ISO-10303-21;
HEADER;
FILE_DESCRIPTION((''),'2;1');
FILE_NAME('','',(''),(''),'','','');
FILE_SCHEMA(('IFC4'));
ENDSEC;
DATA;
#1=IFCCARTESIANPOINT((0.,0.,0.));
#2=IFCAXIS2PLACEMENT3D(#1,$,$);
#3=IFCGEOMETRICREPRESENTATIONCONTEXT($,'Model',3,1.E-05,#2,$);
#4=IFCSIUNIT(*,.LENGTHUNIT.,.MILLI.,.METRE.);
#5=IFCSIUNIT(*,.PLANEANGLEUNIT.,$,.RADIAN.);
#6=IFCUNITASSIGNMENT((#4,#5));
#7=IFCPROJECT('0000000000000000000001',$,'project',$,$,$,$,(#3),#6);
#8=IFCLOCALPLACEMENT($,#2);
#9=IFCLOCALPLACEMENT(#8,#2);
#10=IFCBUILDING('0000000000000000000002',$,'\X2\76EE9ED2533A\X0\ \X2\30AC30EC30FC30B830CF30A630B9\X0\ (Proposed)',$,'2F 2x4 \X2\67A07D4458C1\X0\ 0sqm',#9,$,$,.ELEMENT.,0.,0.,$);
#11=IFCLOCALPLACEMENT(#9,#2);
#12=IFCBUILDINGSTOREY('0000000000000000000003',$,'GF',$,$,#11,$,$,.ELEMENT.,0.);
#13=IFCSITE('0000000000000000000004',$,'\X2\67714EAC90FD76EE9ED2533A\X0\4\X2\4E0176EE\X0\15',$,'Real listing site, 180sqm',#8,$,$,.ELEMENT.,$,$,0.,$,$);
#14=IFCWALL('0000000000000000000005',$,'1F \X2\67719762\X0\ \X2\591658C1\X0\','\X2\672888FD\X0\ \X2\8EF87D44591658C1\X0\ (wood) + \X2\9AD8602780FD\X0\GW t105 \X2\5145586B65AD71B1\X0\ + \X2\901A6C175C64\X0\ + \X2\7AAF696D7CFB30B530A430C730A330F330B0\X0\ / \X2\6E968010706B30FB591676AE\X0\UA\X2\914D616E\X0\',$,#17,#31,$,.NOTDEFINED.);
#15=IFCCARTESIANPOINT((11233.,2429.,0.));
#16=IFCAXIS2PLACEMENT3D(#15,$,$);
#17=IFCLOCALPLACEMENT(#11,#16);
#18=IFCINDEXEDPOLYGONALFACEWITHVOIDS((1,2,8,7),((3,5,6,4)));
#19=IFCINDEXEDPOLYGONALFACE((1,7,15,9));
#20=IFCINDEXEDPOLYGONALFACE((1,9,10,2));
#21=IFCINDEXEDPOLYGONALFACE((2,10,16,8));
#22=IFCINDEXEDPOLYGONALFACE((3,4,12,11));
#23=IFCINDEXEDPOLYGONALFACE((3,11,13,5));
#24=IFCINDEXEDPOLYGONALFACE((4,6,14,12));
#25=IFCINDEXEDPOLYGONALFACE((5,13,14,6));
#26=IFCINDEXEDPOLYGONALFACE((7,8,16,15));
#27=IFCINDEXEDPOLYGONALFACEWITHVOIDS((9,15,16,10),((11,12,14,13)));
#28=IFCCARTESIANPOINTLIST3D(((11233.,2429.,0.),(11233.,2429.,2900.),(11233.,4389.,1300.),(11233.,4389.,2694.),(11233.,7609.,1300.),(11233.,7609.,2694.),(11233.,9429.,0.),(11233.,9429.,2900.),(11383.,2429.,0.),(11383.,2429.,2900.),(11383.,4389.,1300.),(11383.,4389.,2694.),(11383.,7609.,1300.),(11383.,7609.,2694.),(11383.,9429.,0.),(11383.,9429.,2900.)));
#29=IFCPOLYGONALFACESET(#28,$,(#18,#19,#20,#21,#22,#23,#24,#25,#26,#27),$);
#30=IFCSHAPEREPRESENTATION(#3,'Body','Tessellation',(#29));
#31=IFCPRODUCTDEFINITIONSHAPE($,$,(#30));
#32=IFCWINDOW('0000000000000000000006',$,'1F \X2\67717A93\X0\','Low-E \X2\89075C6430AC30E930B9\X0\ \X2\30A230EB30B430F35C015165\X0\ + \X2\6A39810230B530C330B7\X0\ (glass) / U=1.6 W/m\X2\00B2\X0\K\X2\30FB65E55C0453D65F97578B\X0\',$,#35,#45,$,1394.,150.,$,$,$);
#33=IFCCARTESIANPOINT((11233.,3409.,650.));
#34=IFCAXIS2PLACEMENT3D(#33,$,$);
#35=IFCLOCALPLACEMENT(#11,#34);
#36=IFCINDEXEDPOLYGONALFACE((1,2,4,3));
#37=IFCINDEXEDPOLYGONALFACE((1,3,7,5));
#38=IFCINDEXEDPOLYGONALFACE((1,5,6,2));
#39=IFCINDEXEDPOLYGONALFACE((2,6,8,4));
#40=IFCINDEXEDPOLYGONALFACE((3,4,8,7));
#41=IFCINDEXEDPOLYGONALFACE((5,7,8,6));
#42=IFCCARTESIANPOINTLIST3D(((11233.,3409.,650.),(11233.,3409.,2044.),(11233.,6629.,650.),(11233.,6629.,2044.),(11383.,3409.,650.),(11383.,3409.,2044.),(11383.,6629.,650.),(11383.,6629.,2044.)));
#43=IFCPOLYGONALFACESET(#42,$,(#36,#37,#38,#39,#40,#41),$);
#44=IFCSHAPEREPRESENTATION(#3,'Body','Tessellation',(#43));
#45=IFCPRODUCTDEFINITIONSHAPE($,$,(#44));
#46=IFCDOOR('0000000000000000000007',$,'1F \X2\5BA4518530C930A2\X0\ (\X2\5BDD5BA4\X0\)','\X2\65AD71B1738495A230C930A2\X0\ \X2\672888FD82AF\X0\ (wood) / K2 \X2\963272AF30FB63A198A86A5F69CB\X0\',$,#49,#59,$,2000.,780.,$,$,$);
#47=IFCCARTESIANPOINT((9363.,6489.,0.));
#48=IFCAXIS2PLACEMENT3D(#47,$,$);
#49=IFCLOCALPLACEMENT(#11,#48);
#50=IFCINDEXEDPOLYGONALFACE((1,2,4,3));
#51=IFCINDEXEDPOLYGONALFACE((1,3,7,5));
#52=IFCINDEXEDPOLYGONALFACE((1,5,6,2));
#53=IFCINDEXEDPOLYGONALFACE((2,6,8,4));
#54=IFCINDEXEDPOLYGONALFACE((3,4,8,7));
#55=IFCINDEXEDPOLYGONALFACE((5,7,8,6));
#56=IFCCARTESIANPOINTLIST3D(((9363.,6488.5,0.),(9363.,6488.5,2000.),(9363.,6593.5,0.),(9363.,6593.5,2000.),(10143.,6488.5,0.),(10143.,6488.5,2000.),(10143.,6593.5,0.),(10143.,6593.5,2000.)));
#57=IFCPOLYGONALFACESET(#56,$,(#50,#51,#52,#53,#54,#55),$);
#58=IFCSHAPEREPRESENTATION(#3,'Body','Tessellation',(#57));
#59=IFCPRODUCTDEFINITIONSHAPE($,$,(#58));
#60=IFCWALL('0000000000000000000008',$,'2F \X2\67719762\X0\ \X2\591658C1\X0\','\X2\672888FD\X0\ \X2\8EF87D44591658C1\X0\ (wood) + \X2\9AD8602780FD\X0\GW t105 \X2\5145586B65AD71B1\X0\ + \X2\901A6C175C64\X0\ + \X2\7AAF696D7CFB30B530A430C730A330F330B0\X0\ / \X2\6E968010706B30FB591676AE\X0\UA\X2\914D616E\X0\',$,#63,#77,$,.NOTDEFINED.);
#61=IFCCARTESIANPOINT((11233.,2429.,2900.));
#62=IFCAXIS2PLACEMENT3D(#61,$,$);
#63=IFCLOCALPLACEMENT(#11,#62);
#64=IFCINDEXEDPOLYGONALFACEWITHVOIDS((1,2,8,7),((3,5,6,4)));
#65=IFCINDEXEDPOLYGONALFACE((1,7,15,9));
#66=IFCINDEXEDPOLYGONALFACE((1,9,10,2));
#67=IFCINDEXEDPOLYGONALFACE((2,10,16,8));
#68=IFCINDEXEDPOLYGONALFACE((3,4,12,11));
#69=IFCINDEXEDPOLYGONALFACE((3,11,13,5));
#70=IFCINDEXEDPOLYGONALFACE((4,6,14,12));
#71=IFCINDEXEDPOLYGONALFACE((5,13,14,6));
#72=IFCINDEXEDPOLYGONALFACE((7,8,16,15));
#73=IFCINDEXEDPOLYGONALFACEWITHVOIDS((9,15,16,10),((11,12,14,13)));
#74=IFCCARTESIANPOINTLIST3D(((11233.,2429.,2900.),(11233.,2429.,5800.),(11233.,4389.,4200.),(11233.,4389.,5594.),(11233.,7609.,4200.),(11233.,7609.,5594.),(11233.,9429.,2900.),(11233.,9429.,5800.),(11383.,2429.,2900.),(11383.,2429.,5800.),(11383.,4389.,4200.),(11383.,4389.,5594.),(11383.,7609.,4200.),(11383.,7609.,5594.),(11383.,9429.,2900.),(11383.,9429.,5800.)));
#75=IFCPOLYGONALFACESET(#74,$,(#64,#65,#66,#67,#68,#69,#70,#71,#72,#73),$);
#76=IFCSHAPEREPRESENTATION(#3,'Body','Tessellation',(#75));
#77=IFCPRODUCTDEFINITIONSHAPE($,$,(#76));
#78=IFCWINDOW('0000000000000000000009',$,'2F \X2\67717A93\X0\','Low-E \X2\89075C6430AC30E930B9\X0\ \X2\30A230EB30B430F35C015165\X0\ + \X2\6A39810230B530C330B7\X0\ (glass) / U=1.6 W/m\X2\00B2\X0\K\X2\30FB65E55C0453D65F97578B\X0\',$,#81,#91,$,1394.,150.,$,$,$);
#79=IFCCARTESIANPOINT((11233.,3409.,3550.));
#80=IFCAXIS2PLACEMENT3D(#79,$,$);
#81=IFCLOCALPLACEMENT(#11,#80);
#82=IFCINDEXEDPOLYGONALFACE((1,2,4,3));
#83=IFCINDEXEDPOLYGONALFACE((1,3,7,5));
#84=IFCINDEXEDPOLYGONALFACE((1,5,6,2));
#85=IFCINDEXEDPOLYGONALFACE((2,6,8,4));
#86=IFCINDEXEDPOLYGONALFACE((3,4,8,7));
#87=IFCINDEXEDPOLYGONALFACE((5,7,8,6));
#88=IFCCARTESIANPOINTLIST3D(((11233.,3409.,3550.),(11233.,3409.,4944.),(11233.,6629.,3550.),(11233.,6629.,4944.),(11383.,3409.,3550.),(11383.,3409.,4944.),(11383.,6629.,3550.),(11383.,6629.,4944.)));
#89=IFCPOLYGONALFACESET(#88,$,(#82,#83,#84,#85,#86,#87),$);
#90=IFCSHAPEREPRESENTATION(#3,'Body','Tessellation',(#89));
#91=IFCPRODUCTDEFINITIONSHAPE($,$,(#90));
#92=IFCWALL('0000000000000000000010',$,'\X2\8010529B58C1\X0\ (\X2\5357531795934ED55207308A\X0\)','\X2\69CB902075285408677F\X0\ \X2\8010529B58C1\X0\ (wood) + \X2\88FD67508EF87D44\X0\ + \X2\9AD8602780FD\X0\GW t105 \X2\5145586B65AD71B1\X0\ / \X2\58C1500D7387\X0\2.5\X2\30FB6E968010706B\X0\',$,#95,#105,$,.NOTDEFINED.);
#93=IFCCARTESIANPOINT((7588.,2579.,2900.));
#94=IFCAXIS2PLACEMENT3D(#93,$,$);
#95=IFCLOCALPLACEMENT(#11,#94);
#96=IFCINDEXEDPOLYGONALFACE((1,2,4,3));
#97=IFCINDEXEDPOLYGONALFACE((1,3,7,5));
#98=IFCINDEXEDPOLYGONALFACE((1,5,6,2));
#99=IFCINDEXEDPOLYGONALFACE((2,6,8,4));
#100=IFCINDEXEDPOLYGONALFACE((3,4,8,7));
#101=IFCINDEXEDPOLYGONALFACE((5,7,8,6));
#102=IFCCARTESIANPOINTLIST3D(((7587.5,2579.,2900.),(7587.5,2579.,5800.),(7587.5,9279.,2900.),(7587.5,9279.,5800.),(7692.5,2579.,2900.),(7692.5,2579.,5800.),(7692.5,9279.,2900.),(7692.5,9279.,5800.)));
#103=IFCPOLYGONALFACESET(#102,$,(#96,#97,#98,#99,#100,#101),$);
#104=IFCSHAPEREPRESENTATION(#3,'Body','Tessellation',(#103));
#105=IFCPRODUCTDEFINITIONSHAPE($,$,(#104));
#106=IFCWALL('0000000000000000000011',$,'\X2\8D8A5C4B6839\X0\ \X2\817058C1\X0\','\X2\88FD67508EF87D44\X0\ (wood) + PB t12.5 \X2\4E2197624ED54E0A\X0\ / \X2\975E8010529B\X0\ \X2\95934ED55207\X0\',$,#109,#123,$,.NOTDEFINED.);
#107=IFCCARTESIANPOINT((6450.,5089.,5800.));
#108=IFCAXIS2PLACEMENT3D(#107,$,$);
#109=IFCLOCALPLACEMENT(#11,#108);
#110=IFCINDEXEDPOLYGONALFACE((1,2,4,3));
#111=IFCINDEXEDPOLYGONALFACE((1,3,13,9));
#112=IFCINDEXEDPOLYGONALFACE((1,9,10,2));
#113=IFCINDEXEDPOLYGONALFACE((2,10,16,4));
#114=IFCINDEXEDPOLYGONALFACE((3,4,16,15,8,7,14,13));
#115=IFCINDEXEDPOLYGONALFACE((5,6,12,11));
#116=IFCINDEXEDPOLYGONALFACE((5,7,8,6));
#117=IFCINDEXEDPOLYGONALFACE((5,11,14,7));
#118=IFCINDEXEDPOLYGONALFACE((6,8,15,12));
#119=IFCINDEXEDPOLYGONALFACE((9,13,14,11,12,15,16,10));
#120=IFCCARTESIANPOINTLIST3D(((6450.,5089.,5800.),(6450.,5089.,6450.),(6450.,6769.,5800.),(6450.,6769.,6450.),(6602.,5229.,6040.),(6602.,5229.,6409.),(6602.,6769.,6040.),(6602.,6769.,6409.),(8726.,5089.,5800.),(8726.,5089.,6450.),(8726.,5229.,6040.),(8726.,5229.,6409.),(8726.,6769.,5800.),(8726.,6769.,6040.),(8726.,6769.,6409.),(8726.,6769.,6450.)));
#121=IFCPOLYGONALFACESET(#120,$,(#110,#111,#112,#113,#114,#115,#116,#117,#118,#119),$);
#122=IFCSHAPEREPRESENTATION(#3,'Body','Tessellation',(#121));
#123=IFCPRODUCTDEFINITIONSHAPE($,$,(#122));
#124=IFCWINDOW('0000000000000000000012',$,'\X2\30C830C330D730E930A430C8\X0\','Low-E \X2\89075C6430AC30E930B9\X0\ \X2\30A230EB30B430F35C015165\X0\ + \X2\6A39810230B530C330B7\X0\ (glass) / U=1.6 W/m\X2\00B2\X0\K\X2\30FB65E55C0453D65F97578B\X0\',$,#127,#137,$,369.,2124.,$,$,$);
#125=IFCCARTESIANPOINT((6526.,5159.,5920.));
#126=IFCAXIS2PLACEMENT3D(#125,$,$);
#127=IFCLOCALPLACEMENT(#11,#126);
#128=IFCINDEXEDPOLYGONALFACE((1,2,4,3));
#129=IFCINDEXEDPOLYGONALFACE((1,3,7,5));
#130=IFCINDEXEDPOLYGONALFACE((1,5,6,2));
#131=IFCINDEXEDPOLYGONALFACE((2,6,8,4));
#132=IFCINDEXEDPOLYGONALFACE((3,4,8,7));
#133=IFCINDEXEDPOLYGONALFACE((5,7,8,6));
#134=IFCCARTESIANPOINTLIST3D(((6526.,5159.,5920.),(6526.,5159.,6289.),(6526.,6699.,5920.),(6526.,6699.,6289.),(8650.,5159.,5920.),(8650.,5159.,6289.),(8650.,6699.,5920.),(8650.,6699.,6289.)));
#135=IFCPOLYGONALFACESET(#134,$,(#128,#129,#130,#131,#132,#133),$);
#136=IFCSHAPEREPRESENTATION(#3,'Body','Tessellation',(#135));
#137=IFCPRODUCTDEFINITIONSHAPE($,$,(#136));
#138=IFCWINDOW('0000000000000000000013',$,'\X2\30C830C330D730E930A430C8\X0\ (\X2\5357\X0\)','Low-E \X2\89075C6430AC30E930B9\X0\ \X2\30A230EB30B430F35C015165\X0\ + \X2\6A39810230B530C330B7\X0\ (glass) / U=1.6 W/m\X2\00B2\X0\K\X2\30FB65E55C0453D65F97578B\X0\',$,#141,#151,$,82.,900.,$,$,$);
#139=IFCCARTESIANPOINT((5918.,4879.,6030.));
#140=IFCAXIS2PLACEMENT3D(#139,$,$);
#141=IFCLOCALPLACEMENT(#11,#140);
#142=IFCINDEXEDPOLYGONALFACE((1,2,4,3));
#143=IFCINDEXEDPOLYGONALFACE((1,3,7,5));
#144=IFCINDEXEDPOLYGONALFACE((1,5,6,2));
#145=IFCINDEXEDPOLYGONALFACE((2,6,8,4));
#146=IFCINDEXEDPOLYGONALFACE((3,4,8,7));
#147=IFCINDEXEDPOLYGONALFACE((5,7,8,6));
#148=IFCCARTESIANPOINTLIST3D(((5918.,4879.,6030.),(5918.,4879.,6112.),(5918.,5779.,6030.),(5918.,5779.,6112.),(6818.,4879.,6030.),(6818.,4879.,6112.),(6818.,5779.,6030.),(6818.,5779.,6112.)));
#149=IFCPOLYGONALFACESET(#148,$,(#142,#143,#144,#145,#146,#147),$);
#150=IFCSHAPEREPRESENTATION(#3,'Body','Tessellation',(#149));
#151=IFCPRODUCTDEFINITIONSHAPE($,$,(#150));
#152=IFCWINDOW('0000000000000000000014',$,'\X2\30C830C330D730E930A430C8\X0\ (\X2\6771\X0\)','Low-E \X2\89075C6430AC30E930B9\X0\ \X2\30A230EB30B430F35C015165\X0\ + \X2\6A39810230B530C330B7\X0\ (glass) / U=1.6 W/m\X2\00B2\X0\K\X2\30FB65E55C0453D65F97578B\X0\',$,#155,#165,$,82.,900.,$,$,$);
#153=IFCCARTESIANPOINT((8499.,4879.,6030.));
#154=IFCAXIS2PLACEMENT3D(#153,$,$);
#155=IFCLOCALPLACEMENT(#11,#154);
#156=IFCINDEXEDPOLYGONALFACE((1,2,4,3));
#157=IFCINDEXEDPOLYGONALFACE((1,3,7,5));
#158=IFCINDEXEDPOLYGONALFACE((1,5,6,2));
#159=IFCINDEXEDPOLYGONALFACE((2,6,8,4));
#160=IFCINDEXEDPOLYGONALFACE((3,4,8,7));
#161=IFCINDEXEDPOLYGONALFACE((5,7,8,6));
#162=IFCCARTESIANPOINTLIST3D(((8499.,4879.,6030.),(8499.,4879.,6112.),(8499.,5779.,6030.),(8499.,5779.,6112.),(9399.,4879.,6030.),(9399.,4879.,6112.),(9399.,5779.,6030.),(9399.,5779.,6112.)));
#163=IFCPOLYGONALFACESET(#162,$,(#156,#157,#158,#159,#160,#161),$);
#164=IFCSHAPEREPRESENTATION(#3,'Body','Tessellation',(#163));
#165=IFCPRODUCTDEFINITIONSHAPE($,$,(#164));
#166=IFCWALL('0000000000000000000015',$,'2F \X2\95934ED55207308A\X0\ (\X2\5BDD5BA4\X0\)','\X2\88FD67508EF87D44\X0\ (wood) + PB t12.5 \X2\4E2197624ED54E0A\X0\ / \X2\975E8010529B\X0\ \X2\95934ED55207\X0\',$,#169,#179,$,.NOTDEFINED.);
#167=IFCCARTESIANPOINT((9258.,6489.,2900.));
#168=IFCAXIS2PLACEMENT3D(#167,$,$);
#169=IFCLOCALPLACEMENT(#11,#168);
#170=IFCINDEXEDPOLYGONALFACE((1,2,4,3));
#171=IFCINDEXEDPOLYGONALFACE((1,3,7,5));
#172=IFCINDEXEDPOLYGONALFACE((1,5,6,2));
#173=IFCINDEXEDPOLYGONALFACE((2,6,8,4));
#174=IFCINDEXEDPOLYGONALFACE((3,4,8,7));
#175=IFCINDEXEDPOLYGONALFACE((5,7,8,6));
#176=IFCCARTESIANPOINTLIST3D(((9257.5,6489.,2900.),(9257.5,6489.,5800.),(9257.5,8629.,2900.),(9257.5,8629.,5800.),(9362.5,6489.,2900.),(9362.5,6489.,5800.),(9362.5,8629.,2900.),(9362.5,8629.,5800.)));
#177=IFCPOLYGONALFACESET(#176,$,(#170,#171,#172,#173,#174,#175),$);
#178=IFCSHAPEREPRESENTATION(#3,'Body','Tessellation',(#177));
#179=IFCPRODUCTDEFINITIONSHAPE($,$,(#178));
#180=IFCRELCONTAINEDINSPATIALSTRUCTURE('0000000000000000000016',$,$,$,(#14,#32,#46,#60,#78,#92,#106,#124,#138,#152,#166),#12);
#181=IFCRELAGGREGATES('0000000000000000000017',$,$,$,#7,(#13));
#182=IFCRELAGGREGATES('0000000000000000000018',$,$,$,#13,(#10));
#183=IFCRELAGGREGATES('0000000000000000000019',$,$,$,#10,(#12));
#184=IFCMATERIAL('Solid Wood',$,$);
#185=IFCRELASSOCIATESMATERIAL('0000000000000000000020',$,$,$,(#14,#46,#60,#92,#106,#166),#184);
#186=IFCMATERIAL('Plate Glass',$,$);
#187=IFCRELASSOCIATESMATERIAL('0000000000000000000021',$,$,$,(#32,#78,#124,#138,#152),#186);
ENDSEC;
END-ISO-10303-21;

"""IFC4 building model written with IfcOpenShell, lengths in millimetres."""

from ifc_helpers import new_model, si_unit, frame, frame_2d, origin, place, context, project, spatial, rectangle, extrude, material, element, fill, save


model = new_model("IFC4")

# Units and contexts
model_context = context("Model", 3, precision=1e-05, world=origin())
ifc_project = project(units=[si_unit("LENGTHUNIT", "METRE", prefix="MILLI"), si_unit("PLANEANGLEUNIT", "RADIAN")], contexts=[model_context])

# Site, building, storey
site_placement = place(None, origin())
site = spatial("IfcSite", under=ifc_project, at=site_placement, Name="東京都目黒区4丁目15", ObjectType="Real listing site, 180sqm", CompositionType="ELEMENT", RefElevation=0.0)
building_placement = place(site_placement, origin())
building = spatial("IfcBuilding", under=site, at=building_placement, Name="目黒区 ガレージハウス (Proposed)", ObjectType="2F 2x4 枠組壁 0sqm", CompositionType="ELEMENT", ElevationOfRefHeight=0.0, ElevationOfTerrain=0.0)
storey_placement = place(building_placement, origin())
storey = spatial("IfcBuildingStorey", under=building, at=storey_placement, Name="GF", CompositionType="ELEMENT", Elevation=0.0)

# Wall, opening, window
ifc_material_1 = material(Name="Solid Wood")
wall_1_placement = place(storey_placement, frame((11233.0, 2429.0, 0.0)))
wall_1 = element("IfcWall", 1, at=wall_1_placement, inside=storey, material=ifc_material_1, Name="1F 東面 外壁", Description="木製 軸組外壁 (wood) + 高性能GW t105 充填断熱 + 通気層 + 窯業系サイディング / 準耐火・外皮UA配慮", PredefinedType="NOTDEFINED", context=model_context, shape_type="SweptSolid", body=[
    extrude(rectangle(XDim=150.0, YDim=7000.0, at=frame_2d((75.0, 3500.0))), frame((11233.0, 2429.0, 0.0)), (0.0, 0.0, 1.0), 2900.0),
])
opening_1_placement = place(storey_placement, frame((11233.0, 3409.0, 650.0)))
opening_1 = element("IfcOpeningElement", 2, at=opening_1_placement, cuts=wall_1, PredefinedType="NOTDEFINED", context=model_context, shape_type="SweptSolid", body=[
    extrude(rectangle(XDim=150.0, YDim=3220.0, at=frame_2d((75.0, 1610.0))), frame((11233.0, 3409.0, 650.0)), (0.0, 0.0, 1.0), 1394.0),
])
ifc_material_2 = material(Name="Plate Glass")
window_1_placement = place(storey_placement, frame((11233.0, 3409.0, 650.0)))
window_1 = element("IfcWindow", 3, at=window_1_placement, inside=storey, material=ifc_material_2, Name="1F 東窓", Description="Low-E 複層ガラス アルゴン封入 + 樹脂サッシ (glass) / U=1.6 W/m²K・日射取得型", OverallHeight=1394.0, OverallWidth=150.0, context=model_context, shape_type="SweptSolid", body=[
    extrude(rectangle(XDim=150.0, YDim=3220.0, at=frame_2d((75.0, 1610.0))), frame((11233.0, 3409.0, 650.0)), (0.0, 0.0, 1.0), 1394.0),
])
fill(opening_1, window_1)

# Door
door_1_placement = place(storey_placement, frame((9363.0, 6489.0, 0.0)))
element("IfcDoor", 4, at=door_1_placement, inside=storey, material=ifc_material_1, Name="1F 室内ドア (寝室)", Description="断熱玄関ドア 木製芯 (wood) / K2 防犯・採風機構", OverallHeight=2000.0, OverallWidth=780.0, context=model_context, shape_type="SweptSolid", body=[
    extrude(rectangle(XDim=780.0, YDim=105.0, at=frame_2d((390.0, 52.0))), frame((9363.0, 6489.0, 0.0)), (0.0, 0.0, 1.0), 2000.0),
])

# Wall, opening, window
wall_2_placement = place(storey_placement, frame((11233.0, 2429.0, 2900.0)))
wall_2 = element("IfcWall", 5, at=wall_2_placement, inside=storey, material=ifc_material_1, Name="2F 東面 外壁", Description="木製 軸組外壁 (wood) + 高性能GW t105 充填断熱 + 通気層 + 窯業系サイディング / 準耐火・外皮UA配慮", PredefinedType="NOTDEFINED", context=model_context, shape_type="SweptSolid", body=[
    extrude(rectangle(XDim=150.0, YDim=7000.0, at=frame_2d((75.0, 3500.0))), frame((11233.0, 2429.0, 2900.0)), (0.0, 0.0, 1.0), 2900.0),
])
opening_2_placement = place(storey_placement, frame((11233.0, 3409.0, 3550.0)))
opening_2 = element("IfcOpeningElement", 6, at=opening_2_placement, cuts=wall_2, PredefinedType="NOTDEFINED", context=model_context, shape_type="SweptSolid", body=[
    extrude(rectangle(XDim=150.0, YDim=3220.0, at=frame_2d((75.0, 1610.0))), frame((11233.0, 3409.0, 3550.0)), (0.0, 0.0, 1.0), 1394.0),
])
window_2_placement = place(storey_placement, frame((11233.0, 3409.0, 3550.0)))
window_2 = element("IfcWindow", 7, at=window_2_placement, inside=storey, material=ifc_material_2, Name="2F 東窓", Description="Low-E 複層ガラス アルゴン封入 + 樹脂サッシ (glass) / U=1.6 W/m²K・日射取得型", OverallHeight=1394.0, OverallWidth=150.0, context=model_context, shape_type="SweptSolid", body=[
    extrude(rectangle(XDim=150.0, YDim=3220.0, at=frame_2d((75.0, 1610.0))), frame((11233.0, 3409.0, 3550.0)), (0.0, 0.0, 1.0), 1394.0),
])
fill(opening_2, window_2)

# Wall
wall_3_placement = place(storey_placement, frame((7588.0, 2579.0, 2900.0)))
element("IfcWall", 8, at=wall_3_placement, inside=storey, material=ifc_material_1, Name="耐力壁 (南北間仕切り)", Description="構造用合板 耐力壁 (wood) + 製材軸組 + 高性能GW t105 充填断熱 / 壁倍率2.5・準耐火", PredefinedType="NOTDEFINED", context=model_context, shape_type="SweptSolid", body=[
    extrude(rectangle(XDim=105.0, YDim=6700.0, at=frame_2d((52.0, 3350.0))), frame((7588.0, 2579.0, 2900.0)), (0.0, 0.0, 1.0), 2900.0),
])

# Wall, openings, windows
wall_4_placement = place(storey_placement, frame((6450.0, 5089.0, 5800.0)))
wall_4 = element("IfcWall", 9, at=wall_4_placement, inside=storey, material=ifc_material_1, Name="越屋根 腰壁", Description="製材軸組 (wood) + PB t12.5 両面仕上 / 非耐力 間仕切", PredefinedType="NOTDEFINED", context=model_context, shape_type="SweptSolid", body=[
    extrude(rectangle(XDim=2276.0, YDim=1680.0, at=frame_2d((1138.0, 840.0))), frame((6450.0, 5089.0, 5800.0)), (0.0, 0.0, 1.0), 650.0),
])
opening_3_placement = place(storey_placement, frame((6526.0, 5159.0, 5920.0)))
opening_3 = element("IfcOpeningElement", 10, at=opening_3_placement, cuts=wall_4, PredefinedType="NOTDEFINED", context=model_context, shape_type="SweptSolid", body=[
    extrude(rectangle(XDim=2124.0, YDim=1540.0, at=frame_2d((1062.0, 770.0))), frame((6526.0, 5159.0, 5920.0)), (0.0, 0.0, 1.0), 369.0),
])
opening_4_placement = place(storey_placement, frame((5918.0, 4879.0, 6030.0)))
opening_4 = element("IfcOpeningElement", 11, at=opening_4_placement, cuts=wall_4, PredefinedType="NOTDEFINED", context=model_context, shape_type="SweptSolid", body=[
    extrude(rectangle(XDim=900.0, YDim=900.0, at=frame_2d((450.0, 450.0))), frame((5918.0, 4879.0, 6030.0)), (0.0, 0.0, 1.0), 82.0),
])
opening_5_placement = place(storey_placement, frame((8499.0, 4879.0, 6030.0)))
opening_5 = element("IfcOpeningElement", 12, at=opening_5_placement, cuts=wall_4, PredefinedType="NOTDEFINED", context=model_context, shape_type="SweptSolid", body=[
    extrude(rectangle(XDim=900.0, YDim=900.0, at=frame_2d((450.0, 450.0))), frame((8499.0, 4879.0, 6030.0)), (0.0, 0.0, 1.0), 82.0),
])
window_3_placement = place(storey_placement, frame((6526.0, 5159.0, 5920.0)))
window_3 = element("IfcWindow", 13, at=window_3_placement, inside=storey, material=ifc_material_2, Name="トップライト", Description="Low-E 複層ガラス アルゴン封入 + 樹脂サッシ (glass) / U=1.6 W/m²K・日射取得型", OverallHeight=369.0, OverallWidth=2124.0, context=model_context, shape_type="SweptSolid", body=[
    extrude(rectangle(XDim=2124.0, YDim=1540.0, at=frame_2d((1062.0, 770.0))), frame((6526.0, 5159.0, 5920.0)), (0.0, 0.0, 1.0), 369.0),
])
fill(opening_3, window_3)
window_4_placement = place(storey_placement, frame((5918.0, 4879.0, 6030.0)))
window_4 = element("IfcWindow", 14, at=window_4_placement, inside=storey, material=ifc_material_2, Name="トップライト (南)", Description="Low-E 複層ガラス アルゴン封入 + 樹脂サッシ (glass) / U=1.6 W/m²K・日射取得型", OverallHeight=82.0, OverallWidth=900.0, context=model_context, shape_type="SweptSolid", body=[
    extrude(rectangle(XDim=900.0, YDim=900.0, at=frame_2d((450.0, 450.0))), frame((5918.0, 4879.0, 6030.0)), (0.0, 0.0, 1.0), 82.0),
])
fill(opening_4, window_4)
window_5_placement = place(storey_placement, frame((8499.0, 4879.0, 6030.0)))
window_5 = element("IfcWindow", 15, at=window_5_placement, inside=storey, material=ifc_material_2, Name="トップライト (東)", Description="Low-E 複層ガラス アルゴン封入 + 樹脂サッシ (glass) / U=1.6 W/m²K・日射取得型", OverallHeight=82.0, OverallWidth=900.0, context=model_context, shape_type="SweptSolid", body=[
    extrude(rectangle(XDim=900.0, YDim=900.0, at=frame_2d((450.0, 450.0))), frame((8499.0, 4879.0, 6030.0)), (0.0, 0.0, 1.0), 82.0),
])
fill(opening_5, window_5)

# Wall
wall_5_placement = place(storey_placement, frame((9258.0, 6489.0, 2900.0)))
element("IfcWall", 16, at=wall_5_placement, inside=storey, material=ifc_material_1, Name="2F 間仕切り (寝室)", Description="製材軸組 (wood) + PB t12.5 両面仕上 / 非耐力 間仕切", PredefinedType="NOTDEFINED", context=model_context, shape_type="SweptSolid", body=[
    extrude(rectangle(XDim=105.0, YDim=2140.0, at=frame_2d((52.0, 1070.0))), frame((9258.0, 6489.0, 2900.0)), (0.0, 0.0, 1.0), 2900.0),
])

save(model, "model.ifc")
